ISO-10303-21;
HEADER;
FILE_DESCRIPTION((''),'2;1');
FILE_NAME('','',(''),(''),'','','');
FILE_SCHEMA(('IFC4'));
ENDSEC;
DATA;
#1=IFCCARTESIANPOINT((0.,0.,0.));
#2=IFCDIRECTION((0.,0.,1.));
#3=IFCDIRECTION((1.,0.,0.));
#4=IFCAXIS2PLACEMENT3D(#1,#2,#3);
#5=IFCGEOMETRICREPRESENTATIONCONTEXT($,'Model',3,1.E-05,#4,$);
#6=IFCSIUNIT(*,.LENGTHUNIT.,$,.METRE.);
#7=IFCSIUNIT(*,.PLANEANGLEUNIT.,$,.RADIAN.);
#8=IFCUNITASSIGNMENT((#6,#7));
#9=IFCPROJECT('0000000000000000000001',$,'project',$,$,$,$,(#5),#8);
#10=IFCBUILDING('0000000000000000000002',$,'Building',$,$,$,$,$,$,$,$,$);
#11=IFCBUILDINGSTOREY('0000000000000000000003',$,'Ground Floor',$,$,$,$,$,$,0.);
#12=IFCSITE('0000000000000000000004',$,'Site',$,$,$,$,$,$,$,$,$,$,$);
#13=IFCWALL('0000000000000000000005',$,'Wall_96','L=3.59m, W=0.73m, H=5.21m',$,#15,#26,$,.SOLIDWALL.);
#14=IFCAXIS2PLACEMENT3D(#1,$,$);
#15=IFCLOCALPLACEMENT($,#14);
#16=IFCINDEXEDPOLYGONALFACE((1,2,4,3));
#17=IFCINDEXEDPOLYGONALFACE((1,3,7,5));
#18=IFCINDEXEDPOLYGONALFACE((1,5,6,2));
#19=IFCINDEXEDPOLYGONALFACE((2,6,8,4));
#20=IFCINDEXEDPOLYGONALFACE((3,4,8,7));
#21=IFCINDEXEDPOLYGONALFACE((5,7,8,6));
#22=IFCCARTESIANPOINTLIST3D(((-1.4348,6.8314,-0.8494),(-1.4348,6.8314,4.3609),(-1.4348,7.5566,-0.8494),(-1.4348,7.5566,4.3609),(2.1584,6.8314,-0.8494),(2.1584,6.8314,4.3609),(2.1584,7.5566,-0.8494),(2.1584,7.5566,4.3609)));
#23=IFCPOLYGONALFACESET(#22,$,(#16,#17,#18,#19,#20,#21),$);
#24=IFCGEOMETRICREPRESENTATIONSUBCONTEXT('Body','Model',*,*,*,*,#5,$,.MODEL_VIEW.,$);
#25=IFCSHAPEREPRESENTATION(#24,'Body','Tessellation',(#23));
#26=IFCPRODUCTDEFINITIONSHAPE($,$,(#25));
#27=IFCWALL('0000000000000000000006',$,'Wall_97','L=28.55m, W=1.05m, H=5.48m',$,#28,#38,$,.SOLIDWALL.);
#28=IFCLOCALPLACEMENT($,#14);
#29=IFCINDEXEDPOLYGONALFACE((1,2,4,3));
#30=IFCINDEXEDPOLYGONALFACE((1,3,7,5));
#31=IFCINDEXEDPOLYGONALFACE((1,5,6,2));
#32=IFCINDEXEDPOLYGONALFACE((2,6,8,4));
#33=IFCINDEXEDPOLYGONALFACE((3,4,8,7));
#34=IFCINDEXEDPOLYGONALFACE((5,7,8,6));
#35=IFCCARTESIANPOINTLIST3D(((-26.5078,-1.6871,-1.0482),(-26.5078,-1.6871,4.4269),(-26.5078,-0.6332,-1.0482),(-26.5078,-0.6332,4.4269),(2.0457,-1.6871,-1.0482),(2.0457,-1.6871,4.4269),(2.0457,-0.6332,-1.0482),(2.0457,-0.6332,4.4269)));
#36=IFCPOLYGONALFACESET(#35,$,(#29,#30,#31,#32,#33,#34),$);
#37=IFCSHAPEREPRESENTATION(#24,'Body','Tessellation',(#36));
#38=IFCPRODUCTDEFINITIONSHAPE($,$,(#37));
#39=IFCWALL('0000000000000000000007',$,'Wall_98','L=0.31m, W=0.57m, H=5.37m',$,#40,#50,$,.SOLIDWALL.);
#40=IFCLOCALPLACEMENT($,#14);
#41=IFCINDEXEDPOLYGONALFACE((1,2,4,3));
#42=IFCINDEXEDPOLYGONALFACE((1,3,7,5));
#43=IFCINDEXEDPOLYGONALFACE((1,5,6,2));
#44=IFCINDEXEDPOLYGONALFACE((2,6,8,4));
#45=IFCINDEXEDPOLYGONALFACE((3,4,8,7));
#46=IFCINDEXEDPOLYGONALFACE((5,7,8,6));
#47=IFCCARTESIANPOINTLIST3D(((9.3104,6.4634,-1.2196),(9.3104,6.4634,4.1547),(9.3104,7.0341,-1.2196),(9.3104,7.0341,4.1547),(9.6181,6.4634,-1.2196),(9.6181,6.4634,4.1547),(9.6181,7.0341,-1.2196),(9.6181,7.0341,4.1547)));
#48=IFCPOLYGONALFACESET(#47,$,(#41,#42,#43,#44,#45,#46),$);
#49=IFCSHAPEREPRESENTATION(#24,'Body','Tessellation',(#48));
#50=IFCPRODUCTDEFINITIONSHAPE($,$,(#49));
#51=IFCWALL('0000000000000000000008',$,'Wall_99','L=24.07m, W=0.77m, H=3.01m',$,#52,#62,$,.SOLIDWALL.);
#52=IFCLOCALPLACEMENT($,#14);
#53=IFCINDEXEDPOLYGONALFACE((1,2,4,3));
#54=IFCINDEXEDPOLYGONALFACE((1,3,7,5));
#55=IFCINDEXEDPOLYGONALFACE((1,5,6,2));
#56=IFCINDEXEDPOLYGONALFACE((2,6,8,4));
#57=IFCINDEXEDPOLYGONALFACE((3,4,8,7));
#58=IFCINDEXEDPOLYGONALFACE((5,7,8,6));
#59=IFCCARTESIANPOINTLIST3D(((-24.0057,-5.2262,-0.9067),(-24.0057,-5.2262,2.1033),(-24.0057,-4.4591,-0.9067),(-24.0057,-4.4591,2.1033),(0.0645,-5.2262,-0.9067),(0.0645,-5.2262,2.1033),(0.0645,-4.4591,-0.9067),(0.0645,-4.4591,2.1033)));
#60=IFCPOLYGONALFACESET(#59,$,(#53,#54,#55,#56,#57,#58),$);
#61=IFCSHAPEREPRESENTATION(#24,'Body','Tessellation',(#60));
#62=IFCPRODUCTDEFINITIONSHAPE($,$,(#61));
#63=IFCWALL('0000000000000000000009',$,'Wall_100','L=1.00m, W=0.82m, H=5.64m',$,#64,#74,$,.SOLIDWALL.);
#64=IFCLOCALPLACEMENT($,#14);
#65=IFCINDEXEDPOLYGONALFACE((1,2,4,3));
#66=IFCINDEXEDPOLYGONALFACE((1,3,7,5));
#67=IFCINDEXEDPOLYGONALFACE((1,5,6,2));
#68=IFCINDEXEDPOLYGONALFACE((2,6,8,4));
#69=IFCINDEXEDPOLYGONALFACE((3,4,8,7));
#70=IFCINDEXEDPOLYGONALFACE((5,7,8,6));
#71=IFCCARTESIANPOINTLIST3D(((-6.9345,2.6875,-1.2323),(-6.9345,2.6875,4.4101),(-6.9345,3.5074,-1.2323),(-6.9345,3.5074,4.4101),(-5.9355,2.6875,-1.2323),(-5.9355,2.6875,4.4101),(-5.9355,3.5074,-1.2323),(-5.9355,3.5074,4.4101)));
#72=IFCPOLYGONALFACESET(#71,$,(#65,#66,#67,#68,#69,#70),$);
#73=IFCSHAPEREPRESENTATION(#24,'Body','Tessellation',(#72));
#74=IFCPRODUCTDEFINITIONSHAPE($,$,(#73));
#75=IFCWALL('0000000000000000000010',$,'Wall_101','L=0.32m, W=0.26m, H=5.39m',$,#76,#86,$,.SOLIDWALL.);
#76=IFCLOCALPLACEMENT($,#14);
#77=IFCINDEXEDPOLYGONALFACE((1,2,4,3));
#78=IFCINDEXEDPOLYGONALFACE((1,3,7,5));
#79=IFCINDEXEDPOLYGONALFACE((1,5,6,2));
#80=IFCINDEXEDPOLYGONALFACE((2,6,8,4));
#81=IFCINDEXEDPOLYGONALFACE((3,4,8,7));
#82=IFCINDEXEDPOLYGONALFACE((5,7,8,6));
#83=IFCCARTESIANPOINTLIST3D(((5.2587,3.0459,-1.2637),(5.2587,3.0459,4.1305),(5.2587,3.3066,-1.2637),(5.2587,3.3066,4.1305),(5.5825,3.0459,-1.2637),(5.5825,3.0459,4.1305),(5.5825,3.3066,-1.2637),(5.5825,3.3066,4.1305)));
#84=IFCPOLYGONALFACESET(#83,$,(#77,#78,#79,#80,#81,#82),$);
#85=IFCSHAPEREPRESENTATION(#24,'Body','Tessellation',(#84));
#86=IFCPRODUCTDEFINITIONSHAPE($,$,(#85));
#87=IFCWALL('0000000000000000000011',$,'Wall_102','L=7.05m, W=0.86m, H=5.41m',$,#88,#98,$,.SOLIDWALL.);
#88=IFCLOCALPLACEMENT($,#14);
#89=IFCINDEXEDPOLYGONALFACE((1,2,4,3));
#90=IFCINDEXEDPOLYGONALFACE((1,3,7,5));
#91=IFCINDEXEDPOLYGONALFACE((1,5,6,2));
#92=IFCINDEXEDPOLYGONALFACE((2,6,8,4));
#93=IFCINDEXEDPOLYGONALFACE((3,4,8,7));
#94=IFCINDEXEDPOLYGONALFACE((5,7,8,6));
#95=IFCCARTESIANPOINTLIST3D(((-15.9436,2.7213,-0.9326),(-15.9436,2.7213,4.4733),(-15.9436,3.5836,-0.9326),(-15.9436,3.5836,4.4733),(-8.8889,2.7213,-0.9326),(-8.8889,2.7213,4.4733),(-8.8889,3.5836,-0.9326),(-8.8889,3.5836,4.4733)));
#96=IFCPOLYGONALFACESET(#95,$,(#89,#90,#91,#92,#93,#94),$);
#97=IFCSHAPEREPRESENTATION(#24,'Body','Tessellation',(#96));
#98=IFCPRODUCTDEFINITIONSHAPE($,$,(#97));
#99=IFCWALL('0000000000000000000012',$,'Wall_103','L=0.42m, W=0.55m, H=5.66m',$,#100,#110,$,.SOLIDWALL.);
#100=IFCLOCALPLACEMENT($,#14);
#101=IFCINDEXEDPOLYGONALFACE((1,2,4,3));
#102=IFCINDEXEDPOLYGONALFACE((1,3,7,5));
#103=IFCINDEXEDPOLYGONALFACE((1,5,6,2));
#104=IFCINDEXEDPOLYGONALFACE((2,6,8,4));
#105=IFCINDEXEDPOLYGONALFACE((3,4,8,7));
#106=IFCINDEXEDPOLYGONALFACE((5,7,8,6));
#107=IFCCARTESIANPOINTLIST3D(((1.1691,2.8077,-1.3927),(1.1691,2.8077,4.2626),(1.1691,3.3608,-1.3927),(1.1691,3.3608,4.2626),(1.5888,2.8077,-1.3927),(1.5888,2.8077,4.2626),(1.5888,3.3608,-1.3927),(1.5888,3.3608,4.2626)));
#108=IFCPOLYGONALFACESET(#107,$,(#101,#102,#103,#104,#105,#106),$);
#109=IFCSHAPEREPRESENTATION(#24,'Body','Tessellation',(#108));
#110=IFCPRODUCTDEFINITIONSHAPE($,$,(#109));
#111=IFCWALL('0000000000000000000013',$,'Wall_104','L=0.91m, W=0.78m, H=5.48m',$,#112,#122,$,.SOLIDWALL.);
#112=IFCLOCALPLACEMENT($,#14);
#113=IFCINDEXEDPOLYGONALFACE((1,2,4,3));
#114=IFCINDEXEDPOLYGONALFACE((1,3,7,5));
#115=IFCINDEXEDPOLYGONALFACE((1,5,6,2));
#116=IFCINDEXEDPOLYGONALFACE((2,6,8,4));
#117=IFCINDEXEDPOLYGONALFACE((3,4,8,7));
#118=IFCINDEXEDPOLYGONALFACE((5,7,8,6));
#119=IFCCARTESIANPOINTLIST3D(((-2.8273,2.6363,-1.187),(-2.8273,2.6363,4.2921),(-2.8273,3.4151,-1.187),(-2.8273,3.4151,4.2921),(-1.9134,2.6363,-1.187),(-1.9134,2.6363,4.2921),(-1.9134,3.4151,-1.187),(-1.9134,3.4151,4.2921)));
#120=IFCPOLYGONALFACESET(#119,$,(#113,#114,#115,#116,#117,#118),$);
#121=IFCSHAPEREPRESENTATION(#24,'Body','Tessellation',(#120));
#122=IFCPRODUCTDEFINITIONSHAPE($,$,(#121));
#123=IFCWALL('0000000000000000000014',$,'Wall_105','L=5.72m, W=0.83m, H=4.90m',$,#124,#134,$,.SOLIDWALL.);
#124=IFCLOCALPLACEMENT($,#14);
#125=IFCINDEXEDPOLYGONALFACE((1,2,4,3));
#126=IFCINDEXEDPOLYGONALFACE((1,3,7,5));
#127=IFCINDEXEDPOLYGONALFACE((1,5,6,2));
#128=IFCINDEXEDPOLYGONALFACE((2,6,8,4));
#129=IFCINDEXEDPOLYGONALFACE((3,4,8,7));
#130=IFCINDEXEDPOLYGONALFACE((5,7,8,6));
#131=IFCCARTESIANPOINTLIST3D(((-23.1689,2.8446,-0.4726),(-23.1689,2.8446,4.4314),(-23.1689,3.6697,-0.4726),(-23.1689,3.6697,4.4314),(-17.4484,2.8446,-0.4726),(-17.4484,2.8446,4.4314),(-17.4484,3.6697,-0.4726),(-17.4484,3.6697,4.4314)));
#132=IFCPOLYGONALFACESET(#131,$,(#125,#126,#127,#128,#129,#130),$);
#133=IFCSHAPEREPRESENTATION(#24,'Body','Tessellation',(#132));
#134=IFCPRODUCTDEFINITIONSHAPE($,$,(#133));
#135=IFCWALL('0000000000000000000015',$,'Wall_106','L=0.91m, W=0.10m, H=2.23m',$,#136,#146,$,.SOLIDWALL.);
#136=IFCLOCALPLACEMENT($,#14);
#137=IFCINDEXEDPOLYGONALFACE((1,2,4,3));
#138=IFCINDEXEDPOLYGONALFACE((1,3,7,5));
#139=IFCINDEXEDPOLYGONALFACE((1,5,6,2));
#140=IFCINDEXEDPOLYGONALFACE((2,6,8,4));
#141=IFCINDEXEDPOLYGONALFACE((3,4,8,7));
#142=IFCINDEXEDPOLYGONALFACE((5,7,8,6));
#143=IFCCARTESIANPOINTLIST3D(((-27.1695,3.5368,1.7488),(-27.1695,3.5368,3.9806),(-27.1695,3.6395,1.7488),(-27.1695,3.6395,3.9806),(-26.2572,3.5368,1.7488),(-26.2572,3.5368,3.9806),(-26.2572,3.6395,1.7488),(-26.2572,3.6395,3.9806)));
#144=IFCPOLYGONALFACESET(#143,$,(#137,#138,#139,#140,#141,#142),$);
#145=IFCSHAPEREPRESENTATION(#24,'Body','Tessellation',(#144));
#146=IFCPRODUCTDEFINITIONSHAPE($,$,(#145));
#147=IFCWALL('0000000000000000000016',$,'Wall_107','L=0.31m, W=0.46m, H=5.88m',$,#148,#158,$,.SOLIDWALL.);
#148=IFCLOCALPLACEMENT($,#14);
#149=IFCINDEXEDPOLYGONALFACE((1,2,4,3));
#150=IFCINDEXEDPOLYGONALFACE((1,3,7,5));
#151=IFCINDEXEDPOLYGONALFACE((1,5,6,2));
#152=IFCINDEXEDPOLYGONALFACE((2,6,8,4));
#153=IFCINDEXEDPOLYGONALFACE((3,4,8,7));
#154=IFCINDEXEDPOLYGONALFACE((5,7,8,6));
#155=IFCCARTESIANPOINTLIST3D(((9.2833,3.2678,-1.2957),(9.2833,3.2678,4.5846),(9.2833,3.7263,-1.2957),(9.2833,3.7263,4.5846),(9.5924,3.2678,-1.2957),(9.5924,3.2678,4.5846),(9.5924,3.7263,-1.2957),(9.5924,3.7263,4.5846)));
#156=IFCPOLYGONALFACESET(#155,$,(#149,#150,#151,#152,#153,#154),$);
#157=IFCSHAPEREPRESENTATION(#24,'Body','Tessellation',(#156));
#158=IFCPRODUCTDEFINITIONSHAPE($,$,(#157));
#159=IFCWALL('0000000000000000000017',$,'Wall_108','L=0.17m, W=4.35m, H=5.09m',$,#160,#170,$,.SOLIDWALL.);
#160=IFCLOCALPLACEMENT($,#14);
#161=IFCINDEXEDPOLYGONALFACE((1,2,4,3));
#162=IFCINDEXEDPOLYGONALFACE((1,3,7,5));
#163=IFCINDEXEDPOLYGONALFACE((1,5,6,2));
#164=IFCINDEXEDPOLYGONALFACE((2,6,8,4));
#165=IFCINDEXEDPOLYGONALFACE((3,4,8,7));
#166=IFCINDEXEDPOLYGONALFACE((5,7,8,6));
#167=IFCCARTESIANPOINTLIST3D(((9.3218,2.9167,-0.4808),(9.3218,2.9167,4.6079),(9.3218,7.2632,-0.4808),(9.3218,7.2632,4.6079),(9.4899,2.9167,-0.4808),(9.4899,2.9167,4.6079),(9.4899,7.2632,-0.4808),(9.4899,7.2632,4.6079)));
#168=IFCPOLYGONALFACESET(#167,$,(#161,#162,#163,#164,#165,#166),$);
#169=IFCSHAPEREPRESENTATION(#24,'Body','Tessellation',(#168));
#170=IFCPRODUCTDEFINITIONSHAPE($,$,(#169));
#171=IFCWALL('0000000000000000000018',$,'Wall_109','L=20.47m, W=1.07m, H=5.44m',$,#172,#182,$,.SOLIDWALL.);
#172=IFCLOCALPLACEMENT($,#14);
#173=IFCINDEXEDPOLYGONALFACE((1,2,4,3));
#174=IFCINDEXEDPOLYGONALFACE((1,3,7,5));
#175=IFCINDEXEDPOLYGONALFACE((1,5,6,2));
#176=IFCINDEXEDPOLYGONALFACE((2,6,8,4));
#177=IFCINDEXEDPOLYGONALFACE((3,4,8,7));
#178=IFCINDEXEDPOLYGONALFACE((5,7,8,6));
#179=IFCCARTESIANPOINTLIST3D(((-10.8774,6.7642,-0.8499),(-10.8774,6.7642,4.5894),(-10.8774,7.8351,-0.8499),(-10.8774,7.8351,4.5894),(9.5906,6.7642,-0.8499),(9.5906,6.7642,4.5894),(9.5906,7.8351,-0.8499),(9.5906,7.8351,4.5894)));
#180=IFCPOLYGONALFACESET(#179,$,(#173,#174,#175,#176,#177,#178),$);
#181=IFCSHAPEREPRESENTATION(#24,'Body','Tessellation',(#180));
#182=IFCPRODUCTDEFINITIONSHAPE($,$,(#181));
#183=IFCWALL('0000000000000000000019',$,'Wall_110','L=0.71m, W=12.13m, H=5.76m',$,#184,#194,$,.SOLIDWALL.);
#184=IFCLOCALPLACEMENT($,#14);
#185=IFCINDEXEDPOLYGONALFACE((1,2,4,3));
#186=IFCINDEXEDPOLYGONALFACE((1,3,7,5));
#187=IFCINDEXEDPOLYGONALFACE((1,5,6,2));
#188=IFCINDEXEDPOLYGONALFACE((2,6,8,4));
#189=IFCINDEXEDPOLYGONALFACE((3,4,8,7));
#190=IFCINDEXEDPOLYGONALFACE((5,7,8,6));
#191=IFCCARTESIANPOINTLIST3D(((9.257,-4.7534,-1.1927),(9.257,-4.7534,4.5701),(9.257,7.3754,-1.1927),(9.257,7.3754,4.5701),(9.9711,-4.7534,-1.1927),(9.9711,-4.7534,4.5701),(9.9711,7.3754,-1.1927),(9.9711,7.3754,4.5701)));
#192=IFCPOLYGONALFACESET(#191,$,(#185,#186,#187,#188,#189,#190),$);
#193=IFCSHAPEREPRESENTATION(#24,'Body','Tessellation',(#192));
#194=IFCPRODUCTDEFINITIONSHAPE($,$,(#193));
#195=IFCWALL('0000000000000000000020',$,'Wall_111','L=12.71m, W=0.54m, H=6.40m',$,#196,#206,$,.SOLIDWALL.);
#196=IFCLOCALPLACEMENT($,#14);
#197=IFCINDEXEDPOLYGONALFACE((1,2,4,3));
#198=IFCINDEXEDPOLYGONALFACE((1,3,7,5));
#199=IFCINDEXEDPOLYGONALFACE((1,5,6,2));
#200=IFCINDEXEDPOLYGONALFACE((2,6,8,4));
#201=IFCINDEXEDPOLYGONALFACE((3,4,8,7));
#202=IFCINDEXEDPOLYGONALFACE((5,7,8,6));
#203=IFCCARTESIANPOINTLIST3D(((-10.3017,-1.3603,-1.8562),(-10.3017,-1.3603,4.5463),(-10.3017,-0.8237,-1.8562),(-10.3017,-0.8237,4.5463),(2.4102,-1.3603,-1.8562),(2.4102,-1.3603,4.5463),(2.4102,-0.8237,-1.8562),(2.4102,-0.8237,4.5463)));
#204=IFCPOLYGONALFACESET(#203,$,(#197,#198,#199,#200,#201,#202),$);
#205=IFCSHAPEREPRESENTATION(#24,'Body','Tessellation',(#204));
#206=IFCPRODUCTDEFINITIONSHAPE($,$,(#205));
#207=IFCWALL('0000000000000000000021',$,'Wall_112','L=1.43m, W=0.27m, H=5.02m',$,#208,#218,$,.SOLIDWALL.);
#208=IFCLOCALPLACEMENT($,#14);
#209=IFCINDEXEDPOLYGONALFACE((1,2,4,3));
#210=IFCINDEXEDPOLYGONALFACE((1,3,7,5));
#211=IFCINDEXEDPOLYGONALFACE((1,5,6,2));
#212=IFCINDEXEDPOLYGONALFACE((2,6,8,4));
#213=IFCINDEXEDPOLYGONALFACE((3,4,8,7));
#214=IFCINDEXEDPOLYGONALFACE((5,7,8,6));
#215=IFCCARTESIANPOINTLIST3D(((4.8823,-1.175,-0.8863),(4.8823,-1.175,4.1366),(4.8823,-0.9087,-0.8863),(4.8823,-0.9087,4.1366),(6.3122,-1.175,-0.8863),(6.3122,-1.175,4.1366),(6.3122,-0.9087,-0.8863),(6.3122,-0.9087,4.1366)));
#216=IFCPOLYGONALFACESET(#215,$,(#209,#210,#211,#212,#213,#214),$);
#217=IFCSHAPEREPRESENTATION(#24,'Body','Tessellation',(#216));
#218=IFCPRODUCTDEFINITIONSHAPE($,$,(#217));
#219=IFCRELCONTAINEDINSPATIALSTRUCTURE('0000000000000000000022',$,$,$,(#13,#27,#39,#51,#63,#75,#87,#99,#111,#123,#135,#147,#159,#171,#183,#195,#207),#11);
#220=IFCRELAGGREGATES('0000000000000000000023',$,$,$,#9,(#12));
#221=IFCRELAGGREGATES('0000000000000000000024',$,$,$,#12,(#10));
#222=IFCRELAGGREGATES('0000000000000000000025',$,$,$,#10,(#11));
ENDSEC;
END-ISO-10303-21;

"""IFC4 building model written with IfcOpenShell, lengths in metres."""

from ifc_helpers import new_model, si_unit, frame, origin_with_axes, origin_2d, context, subcontext, project, spatial, rectangle, extrude, element, save


model = new_model("IFC4")

# Units and contexts
model_context = context("Model", 3, precision=1e-05, world=origin_with_axes())
body_context = subcontext(model_context, "Body", "Model", "MODEL_VIEW")
ifc_project = project(units=[si_unit("LENGTHUNIT", "METRE"), si_unit("PLANEANGLEUNIT", "RADIAN")], contexts=[model_context])

# Site, building, storey
site = spatial("IfcSite", under=ifc_project, Name="Site")
building = spatial("IfcBuilding", under=site, Name="Building")
storey = spatial("IfcBuildingStorey", under=building, Name="Ground Floor", Elevation=0.0)

# Walls
element("IfcWall", 1, inside=storey, Name="Wall_96", Description="L=3.59m, W=0.73m, H=5.21m", PredefinedType="SOLIDWALL", context=body_context, shape_type="SweptSolid", body=[
    extrude(rectangle(XDim=3.5931, YDim=0.7253, at=origin_2d()), frame((0.3618, 7.194, -0.8494), z_axis=(0.0, 0.0, 1.0), x_axis=(1.0, 0.0, 0.0)), (0.0, 0.0, 1.0), 5.2103),
])
element("IfcWall", 2, inside=storey, Name="Wall_97", Description="L=28.55m, W=1.05m, H=5.48m", PredefinedType="SOLIDWALL", context=body_context, shape_type="SweptSolid", body=[
    extrude(rectangle(XDim=28.5534, YDim=1.0539, at=origin_2d()), frame((-12.231, -1.1601, -1.0482), z_axis=(0.0, 0.0, 1.0), x_axis=(1.0, 0.0, 0.0)), (0.0, 0.0, 1.0), 5.4752),
])
element("IfcWall", 3, inside=storey, Name="Wall_98", Description="L=0.31m, W=0.57m, H=5.37m", PredefinedType="SOLIDWALL", context=body_context, shape_type="SweptSolid", body=[
    extrude(rectangle(XDim=0.3077, YDim=0.5707, at=origin_2d()), frame((9.4642, 6.7487, -1.2196), z_axis=(0.0, 0.0, 1.0), x_axis=(1.0, 0.0, 0.0)), (0.0, 0.0, 1.0), 5.3743),
])
element("IfcWall", 4, inside=storey, Name="Wall_99", Description="L=24.07m, W=0.77m, H=3.01m", PredefinedType="SOLIDWALL", context=body_context, shape_type="SweptSolid", body=[
    extrude(rectangle(XDim=24.0702, YDim=0.7671, at=origin_2d()), frame((-11.9706, -4.8426, -0.9067), z_axis=(0.0, 0.0, 1.0), x_axis=(1.0, 0.0, 0.0)), (0.0, 0.0, 1.0), 3.01),
])
element("IfcWall", 5, inside=storey, Name="Wall_100", Description="L=1.00m, W=0.82m, H=5.64m", PredefinedType="SOLIDWALL", context=body_context, shape_type="SweptSolid", body=[
    extrude(rectangle(XDim=0.999, YDim=0.8198, at=origin_2d()), frame((-6.435, 3.0974, -1.2323), z_axis=(0.0, 0.0, 1.0), x_axis=(1.0, 0.0, 0.0)), (0.0, 0.0, 1.0), 5.6424),
])
element("IfcWall", 6, inside=storey, Name="Wall_101", Description="L=0.32m, W=0.26m, H=5.39m", PredefinedType="SOLIDWALL", context=body_context, shape_type="SweptSolid", body=[
    extrude(rectangle(XDim=0.3237, YDim=0.2606, at=origin_2d()), frame((5.4206, 3.1763, -1.2637), z_axis=(0.0, 0.0, 1.0), x_axis=(1.0, 0.0, 0.0)), (0.0, 0.0, 1.0), 5.3941),
])
element("IfcWall", 7, inside=storey, Name="Wall_102", Description="L=7.05m, W=0.86m, H=5.41m", PredefinedType="SOLIDWALL", context=body_context, shape_type="SweptSolid", body=[
    extrude(rectangle(XDim=7.0547, YDim=0.8623, at=origin_2d()), frame((-12.4163, 3.1524, -0.9326), z_axis=(0.0, 0.0, 1.0), x_axis=(1.0, 0.0, 0.0)), (0.0, 0.0, 1.0), 5.4059),
])
element("IfcWall", 8, inside=storey, Name="Wall_103", Description="L=0.42m, W=0.55m, H=5.66m", PredefinedType="SOLIDWALL", context=body_context, shape_type="SweptSolid", body=[
    extrude(rectangle(XDim=0.4197, YDim=0.5531, at=origin_2d()), frame((1.379, 3.0842, -1.3927), z_axis=(0.0, 0.0, 1.0), x_axis=(1.0, 0.0, 0.0)), (0.0, 0.0, 1.0), 5.6553),
])
element("IfcWall", 9, inside=storey, Name="Wall_104", Description="L=0.91m, W=0.78m, H=5.48m", PredefinedType="SOLIDWALL", context=body_context, shape_type="SweptSolid", body=[
    extrude(rectangle(XDim=0.9138, YDim=0.7788, at=origin_2d()), frame((-2.3703, 3.0257, -1.187), z_axis=(0.0, 0.0, 1.0), x_axis=(1.0, 0.0, 0.0)), (0.0, 0.0, 1.0), 5.4791),
])
element("IfcWall", 10, inside=storey, Name="Wall_105", Description="L=5.72m, W=0.83m, H=4.90m", PredefinedType="SOLIDWALL", context=body_context, shape_type="SweptSolid", body=[
    extrude(rectangle(XDim=5.7205, YDim=0.8251, at=origin_2d()), frame((-20.3086, 3.2571, -0.4726), z_axis=(0.0, 0.0, 1.0), x_axis=(1.0, 0.0, 0.0)), (0.0, 0.0, 1.0), 4.9039),
])
element("IfcWall", 11, inside=storey, Name="Wall_106", Description="L=0.91m, W=0.10m, H=2.23m", PredefinedType="SOLIDWALL", context=body_context, shape_type="SweptSolid", body=[
    extrude(rectangle(XDim=0.9124, YDim=0.1028, at=origin_2d()), frame((-26.7134, 3.5881, 1.7488), z_axis=(0.0, 0.0, 1.0), x_axis=(1.0, 0.0, 0.0)), (0.0, 0.0, 1.0), 2.2317),
])
element("IfcWall", 12, inside=storey, Name="Wall_107", Description="L=0.31m, W=0.46m, H=5.88m", PredefinedType="SOLIDWALL", context=body_context, shape_type="SweptSolid", body=[
    extrude(rectangle(XDim=0.3092, YDim=0.4585, at=origin_2d()), frame((9.4379, 3.497, -1.2957), z_axis=(0.0, 0.0, 1.0), x_axis=(1.0, 0.0, 0.0)), (0.0, 0.0, 1.0), 5.8803),
])
element("IfcWall", 13, inside=storey, Name="Wall_108", Description="L=0.17m, W=4.35m, H=5.09m", PredefinedType="SOLIDWALL", context=body_context, shape_type="SweptSolid", body=[
    extrude(rectangle(XDim=0.1681, YDim=4.3465, at=origin_2d()), frame((9.4059, 5.09, -0.4808), z_axis=(0.0, 0.0, 1.0), x_axis=(1.0, 0.0, 0.0)), (0.0, 0.0, 1.0), 5.0886),
])
element("IfcWall", 14, inside=storey, Name="Wall_109", Description="L=20.47m, W=1.07m, H=5.44m", PredefinedType="SOLIDWALL", context=body_context, shape_type="SweptSolid", body=[
    extrude(rectangle(XDim=20.468, YDim=1.0709, at=origin_2d()), frame((-0.6434, 7.2996, -0.8499), z_axis=(0.0, 0.0, 1.0), x_axis=(1.0, 0.0, 0.0)), (0.0, 0.0, 1.0), 5.4393),
])
element("IfcWall", 15, inside=storey, Name="Wall_110", Description="L=0.71m, W=12.13m, H=5.76m", PredefinedType="SOLIDWALL", context=body_context, shape_type="SweptSolid", body=[
    extrude(rectangle(XDim=0.7141, YDim=12.1288, at=origin_2d()), frame((9.614, 1.311, -1.1927), z_axis=(0.0, 0.0, 1.0), x_axis=(1.0, 0.0, 0.0)), (0.0, 0.0, 1.0), 5.7628),
])
element("IfcWall", 16, inside=storey, Name="Wall_111", Description="L=12.71m, W=0.54m, H=6.40m", PredefinedType="SOLIDWALL", context=body_context, shape_type="SweptSolid", body=[
    extrude(rectangle(XDim=12.7119, YDim=0.5366, at=origin_2d()), frame((-3.9457, -1.092, -1.8562), z_axis=(0.0, 0.0, 1.0), x_axis=(1.0, 0.0, 0.0)), (0.0, 0.0, 1.0), 6.4025),
])
element("IfcWall", 17, inside=storey, Name="Wall_112", Description="L=1.43m, W=0.27m, H=5.02m", PredefinedType="SOLIDWALL", context=body_context, shape_type="SweptSolid", body=[
    extrude(rectangle(XDim=1.43, YDim=0.2663, at=origin_2d()), frame((5.5972, -1.0419, -0.8863), z_axis=(0.0, 0.0, 1.0), x_axis=(1.0, 0.0, 0.0)), (0.0, 0.0, 1.0), 5.0229),
])

save(model, "model.ifc")
